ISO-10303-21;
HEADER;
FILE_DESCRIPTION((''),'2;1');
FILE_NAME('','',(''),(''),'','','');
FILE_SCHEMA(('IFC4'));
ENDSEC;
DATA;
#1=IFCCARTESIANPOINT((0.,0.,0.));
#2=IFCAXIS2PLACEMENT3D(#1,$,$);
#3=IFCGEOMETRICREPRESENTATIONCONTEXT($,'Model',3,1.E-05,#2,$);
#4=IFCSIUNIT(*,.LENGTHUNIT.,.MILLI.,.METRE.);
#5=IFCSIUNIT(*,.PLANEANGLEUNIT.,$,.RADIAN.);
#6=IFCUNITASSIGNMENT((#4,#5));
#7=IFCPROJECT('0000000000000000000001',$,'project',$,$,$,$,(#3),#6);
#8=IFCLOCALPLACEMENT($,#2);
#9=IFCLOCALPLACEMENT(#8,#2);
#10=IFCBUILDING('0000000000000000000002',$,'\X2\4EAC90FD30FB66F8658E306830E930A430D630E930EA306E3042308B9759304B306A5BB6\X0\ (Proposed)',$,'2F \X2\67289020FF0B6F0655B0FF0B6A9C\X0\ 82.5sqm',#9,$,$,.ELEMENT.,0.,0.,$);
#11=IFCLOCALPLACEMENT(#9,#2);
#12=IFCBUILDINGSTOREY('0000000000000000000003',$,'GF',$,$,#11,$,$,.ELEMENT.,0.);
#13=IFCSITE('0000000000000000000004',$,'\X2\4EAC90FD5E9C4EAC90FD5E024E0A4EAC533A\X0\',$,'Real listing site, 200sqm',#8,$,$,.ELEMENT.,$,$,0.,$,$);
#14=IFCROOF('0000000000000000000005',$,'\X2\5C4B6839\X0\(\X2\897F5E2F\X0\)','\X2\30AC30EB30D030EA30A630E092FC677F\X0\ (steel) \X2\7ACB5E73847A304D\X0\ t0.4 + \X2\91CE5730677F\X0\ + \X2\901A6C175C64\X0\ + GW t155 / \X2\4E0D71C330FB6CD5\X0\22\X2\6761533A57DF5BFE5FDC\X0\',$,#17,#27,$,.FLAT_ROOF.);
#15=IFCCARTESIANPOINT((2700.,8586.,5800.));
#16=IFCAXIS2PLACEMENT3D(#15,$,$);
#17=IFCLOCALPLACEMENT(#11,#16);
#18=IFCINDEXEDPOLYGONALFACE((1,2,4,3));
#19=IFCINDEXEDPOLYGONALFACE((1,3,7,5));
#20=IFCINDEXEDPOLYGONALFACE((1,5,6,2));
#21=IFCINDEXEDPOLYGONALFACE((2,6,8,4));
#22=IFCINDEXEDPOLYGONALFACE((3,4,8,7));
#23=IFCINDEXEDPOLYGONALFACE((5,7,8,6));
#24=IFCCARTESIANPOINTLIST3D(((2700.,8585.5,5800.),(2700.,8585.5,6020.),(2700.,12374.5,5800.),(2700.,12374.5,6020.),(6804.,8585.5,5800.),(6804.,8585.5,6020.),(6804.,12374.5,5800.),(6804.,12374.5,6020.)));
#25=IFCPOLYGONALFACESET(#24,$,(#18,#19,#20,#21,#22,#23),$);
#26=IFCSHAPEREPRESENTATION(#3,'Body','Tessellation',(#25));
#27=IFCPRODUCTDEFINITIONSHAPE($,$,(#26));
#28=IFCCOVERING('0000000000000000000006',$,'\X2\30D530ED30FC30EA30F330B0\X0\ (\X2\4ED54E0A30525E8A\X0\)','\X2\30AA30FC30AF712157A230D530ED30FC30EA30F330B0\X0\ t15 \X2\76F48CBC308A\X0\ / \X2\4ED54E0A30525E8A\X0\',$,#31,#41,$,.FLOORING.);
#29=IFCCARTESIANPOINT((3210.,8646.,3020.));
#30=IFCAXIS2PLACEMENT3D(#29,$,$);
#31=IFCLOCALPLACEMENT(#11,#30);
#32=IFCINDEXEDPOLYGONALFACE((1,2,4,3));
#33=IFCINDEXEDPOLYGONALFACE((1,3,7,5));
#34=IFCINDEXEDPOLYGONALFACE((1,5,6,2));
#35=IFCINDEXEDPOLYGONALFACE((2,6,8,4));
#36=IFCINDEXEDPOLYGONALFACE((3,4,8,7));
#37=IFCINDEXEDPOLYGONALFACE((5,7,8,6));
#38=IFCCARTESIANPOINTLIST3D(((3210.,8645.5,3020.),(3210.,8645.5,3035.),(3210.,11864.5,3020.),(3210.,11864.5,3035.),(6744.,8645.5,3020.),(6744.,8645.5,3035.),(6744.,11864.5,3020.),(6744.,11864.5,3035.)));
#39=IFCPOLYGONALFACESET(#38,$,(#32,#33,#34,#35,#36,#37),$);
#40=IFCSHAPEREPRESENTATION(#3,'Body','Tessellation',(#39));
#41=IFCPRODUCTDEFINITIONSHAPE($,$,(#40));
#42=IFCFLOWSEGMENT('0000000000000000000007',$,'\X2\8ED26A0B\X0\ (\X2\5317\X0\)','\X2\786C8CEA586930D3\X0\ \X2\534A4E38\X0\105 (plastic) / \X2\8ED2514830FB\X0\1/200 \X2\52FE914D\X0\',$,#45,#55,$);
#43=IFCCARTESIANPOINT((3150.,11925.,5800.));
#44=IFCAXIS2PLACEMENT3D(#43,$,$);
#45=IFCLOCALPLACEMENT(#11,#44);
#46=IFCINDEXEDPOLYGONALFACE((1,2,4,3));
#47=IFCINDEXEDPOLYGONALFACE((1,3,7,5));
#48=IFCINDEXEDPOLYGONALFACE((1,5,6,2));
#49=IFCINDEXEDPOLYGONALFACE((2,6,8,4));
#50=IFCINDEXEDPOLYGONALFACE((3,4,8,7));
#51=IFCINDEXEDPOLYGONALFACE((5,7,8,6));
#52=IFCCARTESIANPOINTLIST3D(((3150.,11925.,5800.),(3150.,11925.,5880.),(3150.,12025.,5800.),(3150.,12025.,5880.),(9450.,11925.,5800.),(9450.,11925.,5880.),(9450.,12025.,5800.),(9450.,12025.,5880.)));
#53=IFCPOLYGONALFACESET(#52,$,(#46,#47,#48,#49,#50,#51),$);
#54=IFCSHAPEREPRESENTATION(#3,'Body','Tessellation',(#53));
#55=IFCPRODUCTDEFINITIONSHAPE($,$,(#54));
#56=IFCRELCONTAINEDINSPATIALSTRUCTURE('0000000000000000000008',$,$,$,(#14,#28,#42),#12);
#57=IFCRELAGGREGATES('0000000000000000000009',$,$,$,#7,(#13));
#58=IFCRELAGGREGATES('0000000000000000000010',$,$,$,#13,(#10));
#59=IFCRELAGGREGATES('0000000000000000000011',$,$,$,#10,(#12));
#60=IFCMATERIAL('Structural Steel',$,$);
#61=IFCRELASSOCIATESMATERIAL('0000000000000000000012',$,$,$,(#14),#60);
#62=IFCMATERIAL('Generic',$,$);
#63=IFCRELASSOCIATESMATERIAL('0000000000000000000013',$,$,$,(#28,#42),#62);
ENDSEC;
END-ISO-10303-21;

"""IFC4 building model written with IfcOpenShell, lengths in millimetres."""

from ifc_helpers import new_model, si_unit, frame, frame_2d, origin, place, context, project, spatial, rectangle, extrude, material, element, save


model = new_model("IFC4")

# Units and contexts
model_context = context("Model", 3, precision=1e-05, world=origin())
ifc_project = project(units=[si_unit("LENGTHUNIT", "METRE", prefix="MILLI"), si_unit("PLANEANGLEUNIT", "RADIAN")], contexts=[model_context])

# Site, building, storey
site_placement = place(None, origin())
site = spatial("IfcSite", under=ifc_project, at=site_placement, Name="京都府京都市上京区", ObjectType="Real listing site, 200sqm", CompositionType="ELEMENT", RefElevation=0.0)
building_placement = place(site_placement, origin())
building = spatial("IfcBuilding", under=site, at=building_placement, Name="京都・書斎とライブラリのある静かな家 (Proposed)", ObjectType="2F 木造＋漆喰＋檜 82.5sqm", CompositionType="ELEMENT", ElevationOfRefHeight=0.0, ElevationOfTerrain=0.0)
storey_placement = place(building_placement, origin())
storey = spatial("IfcBuildingStorey", under=building, at=storey_placement, Name="GF", CompositionType="ELEMENT", Elevation=0.0)

# Roof
ifc_material_1 = material(Name="Structural Steel")
for number, where, name in (
    (1, (2700.0, 8586.0, 5800.0), "屋根(西帯)"),
):
    element("IfcRoof", number, at=place(storey_placement, frame(where)), inside=storey, material=ifc_material_1, Name=name, Description="ガルバリウム鋼板 (steel) 立平葺き t0.4 + 野地板 + 通気層 + GW t155 / 不燃・法22条区域対応", PredefinedType="FLAT_ROOF", context=model_context, shape_type="SweptSolid", body=[
        extrude(rectangle(XDim=4104.0, YDim=3789.0, at=frame_2d((2052.0, 1894.0))), frame((2700.0, 8586.0, 5800.0)), (0.0, 0.0, 1.0), 220.0),
    ])

# Covering
ifc_material_2 = material(Name="Generic")
covering_placement = place(storey_placement, frame((3210.0, 8646.0, 3020.0)))
element("IfcCovering", 2, at=covering_placement, inside=storey, material=ifc_material_2, Name="フローリング (仕上げ床)", Description="オーク無垢フローリング t15 直貼り / 仕上げ床", PredefinedType="FLOORING", context=model_context, shape_type="SweptSolid", body=[
    extrude(rectangle(XDim=3534.0, YDim=3219.0, at=frame_2d((1767.0, 1609.0))), frame((3210.0, 8646.0, 3020.0)), (0.0, 0.0, 1.0), 15.0),
])

# Flow segment
flow_segment_placement = place(storey_placement, frame((3150.0, 11925.0, 5800.0)))
element("IfcFlowSegment", 3, at=flow_segment_placement, inside=storey, material=ifc_material_2, Name="軒樋 (北)", Description="硬質塩ビ 半丸105 (plastic) / 軒先・1/200 勾配", context=model_context, shape_type="SweptSolid", body=[
    extrude(rectangle(XDim=6300.0, YDim=100.0, at=frame_2d((3150.0, 50.0))), frame((3150.0, 11925.0, 5800.0)), (0.0, 0.0, 1.0), 80.0),
])

save(model, "model.ifc")
